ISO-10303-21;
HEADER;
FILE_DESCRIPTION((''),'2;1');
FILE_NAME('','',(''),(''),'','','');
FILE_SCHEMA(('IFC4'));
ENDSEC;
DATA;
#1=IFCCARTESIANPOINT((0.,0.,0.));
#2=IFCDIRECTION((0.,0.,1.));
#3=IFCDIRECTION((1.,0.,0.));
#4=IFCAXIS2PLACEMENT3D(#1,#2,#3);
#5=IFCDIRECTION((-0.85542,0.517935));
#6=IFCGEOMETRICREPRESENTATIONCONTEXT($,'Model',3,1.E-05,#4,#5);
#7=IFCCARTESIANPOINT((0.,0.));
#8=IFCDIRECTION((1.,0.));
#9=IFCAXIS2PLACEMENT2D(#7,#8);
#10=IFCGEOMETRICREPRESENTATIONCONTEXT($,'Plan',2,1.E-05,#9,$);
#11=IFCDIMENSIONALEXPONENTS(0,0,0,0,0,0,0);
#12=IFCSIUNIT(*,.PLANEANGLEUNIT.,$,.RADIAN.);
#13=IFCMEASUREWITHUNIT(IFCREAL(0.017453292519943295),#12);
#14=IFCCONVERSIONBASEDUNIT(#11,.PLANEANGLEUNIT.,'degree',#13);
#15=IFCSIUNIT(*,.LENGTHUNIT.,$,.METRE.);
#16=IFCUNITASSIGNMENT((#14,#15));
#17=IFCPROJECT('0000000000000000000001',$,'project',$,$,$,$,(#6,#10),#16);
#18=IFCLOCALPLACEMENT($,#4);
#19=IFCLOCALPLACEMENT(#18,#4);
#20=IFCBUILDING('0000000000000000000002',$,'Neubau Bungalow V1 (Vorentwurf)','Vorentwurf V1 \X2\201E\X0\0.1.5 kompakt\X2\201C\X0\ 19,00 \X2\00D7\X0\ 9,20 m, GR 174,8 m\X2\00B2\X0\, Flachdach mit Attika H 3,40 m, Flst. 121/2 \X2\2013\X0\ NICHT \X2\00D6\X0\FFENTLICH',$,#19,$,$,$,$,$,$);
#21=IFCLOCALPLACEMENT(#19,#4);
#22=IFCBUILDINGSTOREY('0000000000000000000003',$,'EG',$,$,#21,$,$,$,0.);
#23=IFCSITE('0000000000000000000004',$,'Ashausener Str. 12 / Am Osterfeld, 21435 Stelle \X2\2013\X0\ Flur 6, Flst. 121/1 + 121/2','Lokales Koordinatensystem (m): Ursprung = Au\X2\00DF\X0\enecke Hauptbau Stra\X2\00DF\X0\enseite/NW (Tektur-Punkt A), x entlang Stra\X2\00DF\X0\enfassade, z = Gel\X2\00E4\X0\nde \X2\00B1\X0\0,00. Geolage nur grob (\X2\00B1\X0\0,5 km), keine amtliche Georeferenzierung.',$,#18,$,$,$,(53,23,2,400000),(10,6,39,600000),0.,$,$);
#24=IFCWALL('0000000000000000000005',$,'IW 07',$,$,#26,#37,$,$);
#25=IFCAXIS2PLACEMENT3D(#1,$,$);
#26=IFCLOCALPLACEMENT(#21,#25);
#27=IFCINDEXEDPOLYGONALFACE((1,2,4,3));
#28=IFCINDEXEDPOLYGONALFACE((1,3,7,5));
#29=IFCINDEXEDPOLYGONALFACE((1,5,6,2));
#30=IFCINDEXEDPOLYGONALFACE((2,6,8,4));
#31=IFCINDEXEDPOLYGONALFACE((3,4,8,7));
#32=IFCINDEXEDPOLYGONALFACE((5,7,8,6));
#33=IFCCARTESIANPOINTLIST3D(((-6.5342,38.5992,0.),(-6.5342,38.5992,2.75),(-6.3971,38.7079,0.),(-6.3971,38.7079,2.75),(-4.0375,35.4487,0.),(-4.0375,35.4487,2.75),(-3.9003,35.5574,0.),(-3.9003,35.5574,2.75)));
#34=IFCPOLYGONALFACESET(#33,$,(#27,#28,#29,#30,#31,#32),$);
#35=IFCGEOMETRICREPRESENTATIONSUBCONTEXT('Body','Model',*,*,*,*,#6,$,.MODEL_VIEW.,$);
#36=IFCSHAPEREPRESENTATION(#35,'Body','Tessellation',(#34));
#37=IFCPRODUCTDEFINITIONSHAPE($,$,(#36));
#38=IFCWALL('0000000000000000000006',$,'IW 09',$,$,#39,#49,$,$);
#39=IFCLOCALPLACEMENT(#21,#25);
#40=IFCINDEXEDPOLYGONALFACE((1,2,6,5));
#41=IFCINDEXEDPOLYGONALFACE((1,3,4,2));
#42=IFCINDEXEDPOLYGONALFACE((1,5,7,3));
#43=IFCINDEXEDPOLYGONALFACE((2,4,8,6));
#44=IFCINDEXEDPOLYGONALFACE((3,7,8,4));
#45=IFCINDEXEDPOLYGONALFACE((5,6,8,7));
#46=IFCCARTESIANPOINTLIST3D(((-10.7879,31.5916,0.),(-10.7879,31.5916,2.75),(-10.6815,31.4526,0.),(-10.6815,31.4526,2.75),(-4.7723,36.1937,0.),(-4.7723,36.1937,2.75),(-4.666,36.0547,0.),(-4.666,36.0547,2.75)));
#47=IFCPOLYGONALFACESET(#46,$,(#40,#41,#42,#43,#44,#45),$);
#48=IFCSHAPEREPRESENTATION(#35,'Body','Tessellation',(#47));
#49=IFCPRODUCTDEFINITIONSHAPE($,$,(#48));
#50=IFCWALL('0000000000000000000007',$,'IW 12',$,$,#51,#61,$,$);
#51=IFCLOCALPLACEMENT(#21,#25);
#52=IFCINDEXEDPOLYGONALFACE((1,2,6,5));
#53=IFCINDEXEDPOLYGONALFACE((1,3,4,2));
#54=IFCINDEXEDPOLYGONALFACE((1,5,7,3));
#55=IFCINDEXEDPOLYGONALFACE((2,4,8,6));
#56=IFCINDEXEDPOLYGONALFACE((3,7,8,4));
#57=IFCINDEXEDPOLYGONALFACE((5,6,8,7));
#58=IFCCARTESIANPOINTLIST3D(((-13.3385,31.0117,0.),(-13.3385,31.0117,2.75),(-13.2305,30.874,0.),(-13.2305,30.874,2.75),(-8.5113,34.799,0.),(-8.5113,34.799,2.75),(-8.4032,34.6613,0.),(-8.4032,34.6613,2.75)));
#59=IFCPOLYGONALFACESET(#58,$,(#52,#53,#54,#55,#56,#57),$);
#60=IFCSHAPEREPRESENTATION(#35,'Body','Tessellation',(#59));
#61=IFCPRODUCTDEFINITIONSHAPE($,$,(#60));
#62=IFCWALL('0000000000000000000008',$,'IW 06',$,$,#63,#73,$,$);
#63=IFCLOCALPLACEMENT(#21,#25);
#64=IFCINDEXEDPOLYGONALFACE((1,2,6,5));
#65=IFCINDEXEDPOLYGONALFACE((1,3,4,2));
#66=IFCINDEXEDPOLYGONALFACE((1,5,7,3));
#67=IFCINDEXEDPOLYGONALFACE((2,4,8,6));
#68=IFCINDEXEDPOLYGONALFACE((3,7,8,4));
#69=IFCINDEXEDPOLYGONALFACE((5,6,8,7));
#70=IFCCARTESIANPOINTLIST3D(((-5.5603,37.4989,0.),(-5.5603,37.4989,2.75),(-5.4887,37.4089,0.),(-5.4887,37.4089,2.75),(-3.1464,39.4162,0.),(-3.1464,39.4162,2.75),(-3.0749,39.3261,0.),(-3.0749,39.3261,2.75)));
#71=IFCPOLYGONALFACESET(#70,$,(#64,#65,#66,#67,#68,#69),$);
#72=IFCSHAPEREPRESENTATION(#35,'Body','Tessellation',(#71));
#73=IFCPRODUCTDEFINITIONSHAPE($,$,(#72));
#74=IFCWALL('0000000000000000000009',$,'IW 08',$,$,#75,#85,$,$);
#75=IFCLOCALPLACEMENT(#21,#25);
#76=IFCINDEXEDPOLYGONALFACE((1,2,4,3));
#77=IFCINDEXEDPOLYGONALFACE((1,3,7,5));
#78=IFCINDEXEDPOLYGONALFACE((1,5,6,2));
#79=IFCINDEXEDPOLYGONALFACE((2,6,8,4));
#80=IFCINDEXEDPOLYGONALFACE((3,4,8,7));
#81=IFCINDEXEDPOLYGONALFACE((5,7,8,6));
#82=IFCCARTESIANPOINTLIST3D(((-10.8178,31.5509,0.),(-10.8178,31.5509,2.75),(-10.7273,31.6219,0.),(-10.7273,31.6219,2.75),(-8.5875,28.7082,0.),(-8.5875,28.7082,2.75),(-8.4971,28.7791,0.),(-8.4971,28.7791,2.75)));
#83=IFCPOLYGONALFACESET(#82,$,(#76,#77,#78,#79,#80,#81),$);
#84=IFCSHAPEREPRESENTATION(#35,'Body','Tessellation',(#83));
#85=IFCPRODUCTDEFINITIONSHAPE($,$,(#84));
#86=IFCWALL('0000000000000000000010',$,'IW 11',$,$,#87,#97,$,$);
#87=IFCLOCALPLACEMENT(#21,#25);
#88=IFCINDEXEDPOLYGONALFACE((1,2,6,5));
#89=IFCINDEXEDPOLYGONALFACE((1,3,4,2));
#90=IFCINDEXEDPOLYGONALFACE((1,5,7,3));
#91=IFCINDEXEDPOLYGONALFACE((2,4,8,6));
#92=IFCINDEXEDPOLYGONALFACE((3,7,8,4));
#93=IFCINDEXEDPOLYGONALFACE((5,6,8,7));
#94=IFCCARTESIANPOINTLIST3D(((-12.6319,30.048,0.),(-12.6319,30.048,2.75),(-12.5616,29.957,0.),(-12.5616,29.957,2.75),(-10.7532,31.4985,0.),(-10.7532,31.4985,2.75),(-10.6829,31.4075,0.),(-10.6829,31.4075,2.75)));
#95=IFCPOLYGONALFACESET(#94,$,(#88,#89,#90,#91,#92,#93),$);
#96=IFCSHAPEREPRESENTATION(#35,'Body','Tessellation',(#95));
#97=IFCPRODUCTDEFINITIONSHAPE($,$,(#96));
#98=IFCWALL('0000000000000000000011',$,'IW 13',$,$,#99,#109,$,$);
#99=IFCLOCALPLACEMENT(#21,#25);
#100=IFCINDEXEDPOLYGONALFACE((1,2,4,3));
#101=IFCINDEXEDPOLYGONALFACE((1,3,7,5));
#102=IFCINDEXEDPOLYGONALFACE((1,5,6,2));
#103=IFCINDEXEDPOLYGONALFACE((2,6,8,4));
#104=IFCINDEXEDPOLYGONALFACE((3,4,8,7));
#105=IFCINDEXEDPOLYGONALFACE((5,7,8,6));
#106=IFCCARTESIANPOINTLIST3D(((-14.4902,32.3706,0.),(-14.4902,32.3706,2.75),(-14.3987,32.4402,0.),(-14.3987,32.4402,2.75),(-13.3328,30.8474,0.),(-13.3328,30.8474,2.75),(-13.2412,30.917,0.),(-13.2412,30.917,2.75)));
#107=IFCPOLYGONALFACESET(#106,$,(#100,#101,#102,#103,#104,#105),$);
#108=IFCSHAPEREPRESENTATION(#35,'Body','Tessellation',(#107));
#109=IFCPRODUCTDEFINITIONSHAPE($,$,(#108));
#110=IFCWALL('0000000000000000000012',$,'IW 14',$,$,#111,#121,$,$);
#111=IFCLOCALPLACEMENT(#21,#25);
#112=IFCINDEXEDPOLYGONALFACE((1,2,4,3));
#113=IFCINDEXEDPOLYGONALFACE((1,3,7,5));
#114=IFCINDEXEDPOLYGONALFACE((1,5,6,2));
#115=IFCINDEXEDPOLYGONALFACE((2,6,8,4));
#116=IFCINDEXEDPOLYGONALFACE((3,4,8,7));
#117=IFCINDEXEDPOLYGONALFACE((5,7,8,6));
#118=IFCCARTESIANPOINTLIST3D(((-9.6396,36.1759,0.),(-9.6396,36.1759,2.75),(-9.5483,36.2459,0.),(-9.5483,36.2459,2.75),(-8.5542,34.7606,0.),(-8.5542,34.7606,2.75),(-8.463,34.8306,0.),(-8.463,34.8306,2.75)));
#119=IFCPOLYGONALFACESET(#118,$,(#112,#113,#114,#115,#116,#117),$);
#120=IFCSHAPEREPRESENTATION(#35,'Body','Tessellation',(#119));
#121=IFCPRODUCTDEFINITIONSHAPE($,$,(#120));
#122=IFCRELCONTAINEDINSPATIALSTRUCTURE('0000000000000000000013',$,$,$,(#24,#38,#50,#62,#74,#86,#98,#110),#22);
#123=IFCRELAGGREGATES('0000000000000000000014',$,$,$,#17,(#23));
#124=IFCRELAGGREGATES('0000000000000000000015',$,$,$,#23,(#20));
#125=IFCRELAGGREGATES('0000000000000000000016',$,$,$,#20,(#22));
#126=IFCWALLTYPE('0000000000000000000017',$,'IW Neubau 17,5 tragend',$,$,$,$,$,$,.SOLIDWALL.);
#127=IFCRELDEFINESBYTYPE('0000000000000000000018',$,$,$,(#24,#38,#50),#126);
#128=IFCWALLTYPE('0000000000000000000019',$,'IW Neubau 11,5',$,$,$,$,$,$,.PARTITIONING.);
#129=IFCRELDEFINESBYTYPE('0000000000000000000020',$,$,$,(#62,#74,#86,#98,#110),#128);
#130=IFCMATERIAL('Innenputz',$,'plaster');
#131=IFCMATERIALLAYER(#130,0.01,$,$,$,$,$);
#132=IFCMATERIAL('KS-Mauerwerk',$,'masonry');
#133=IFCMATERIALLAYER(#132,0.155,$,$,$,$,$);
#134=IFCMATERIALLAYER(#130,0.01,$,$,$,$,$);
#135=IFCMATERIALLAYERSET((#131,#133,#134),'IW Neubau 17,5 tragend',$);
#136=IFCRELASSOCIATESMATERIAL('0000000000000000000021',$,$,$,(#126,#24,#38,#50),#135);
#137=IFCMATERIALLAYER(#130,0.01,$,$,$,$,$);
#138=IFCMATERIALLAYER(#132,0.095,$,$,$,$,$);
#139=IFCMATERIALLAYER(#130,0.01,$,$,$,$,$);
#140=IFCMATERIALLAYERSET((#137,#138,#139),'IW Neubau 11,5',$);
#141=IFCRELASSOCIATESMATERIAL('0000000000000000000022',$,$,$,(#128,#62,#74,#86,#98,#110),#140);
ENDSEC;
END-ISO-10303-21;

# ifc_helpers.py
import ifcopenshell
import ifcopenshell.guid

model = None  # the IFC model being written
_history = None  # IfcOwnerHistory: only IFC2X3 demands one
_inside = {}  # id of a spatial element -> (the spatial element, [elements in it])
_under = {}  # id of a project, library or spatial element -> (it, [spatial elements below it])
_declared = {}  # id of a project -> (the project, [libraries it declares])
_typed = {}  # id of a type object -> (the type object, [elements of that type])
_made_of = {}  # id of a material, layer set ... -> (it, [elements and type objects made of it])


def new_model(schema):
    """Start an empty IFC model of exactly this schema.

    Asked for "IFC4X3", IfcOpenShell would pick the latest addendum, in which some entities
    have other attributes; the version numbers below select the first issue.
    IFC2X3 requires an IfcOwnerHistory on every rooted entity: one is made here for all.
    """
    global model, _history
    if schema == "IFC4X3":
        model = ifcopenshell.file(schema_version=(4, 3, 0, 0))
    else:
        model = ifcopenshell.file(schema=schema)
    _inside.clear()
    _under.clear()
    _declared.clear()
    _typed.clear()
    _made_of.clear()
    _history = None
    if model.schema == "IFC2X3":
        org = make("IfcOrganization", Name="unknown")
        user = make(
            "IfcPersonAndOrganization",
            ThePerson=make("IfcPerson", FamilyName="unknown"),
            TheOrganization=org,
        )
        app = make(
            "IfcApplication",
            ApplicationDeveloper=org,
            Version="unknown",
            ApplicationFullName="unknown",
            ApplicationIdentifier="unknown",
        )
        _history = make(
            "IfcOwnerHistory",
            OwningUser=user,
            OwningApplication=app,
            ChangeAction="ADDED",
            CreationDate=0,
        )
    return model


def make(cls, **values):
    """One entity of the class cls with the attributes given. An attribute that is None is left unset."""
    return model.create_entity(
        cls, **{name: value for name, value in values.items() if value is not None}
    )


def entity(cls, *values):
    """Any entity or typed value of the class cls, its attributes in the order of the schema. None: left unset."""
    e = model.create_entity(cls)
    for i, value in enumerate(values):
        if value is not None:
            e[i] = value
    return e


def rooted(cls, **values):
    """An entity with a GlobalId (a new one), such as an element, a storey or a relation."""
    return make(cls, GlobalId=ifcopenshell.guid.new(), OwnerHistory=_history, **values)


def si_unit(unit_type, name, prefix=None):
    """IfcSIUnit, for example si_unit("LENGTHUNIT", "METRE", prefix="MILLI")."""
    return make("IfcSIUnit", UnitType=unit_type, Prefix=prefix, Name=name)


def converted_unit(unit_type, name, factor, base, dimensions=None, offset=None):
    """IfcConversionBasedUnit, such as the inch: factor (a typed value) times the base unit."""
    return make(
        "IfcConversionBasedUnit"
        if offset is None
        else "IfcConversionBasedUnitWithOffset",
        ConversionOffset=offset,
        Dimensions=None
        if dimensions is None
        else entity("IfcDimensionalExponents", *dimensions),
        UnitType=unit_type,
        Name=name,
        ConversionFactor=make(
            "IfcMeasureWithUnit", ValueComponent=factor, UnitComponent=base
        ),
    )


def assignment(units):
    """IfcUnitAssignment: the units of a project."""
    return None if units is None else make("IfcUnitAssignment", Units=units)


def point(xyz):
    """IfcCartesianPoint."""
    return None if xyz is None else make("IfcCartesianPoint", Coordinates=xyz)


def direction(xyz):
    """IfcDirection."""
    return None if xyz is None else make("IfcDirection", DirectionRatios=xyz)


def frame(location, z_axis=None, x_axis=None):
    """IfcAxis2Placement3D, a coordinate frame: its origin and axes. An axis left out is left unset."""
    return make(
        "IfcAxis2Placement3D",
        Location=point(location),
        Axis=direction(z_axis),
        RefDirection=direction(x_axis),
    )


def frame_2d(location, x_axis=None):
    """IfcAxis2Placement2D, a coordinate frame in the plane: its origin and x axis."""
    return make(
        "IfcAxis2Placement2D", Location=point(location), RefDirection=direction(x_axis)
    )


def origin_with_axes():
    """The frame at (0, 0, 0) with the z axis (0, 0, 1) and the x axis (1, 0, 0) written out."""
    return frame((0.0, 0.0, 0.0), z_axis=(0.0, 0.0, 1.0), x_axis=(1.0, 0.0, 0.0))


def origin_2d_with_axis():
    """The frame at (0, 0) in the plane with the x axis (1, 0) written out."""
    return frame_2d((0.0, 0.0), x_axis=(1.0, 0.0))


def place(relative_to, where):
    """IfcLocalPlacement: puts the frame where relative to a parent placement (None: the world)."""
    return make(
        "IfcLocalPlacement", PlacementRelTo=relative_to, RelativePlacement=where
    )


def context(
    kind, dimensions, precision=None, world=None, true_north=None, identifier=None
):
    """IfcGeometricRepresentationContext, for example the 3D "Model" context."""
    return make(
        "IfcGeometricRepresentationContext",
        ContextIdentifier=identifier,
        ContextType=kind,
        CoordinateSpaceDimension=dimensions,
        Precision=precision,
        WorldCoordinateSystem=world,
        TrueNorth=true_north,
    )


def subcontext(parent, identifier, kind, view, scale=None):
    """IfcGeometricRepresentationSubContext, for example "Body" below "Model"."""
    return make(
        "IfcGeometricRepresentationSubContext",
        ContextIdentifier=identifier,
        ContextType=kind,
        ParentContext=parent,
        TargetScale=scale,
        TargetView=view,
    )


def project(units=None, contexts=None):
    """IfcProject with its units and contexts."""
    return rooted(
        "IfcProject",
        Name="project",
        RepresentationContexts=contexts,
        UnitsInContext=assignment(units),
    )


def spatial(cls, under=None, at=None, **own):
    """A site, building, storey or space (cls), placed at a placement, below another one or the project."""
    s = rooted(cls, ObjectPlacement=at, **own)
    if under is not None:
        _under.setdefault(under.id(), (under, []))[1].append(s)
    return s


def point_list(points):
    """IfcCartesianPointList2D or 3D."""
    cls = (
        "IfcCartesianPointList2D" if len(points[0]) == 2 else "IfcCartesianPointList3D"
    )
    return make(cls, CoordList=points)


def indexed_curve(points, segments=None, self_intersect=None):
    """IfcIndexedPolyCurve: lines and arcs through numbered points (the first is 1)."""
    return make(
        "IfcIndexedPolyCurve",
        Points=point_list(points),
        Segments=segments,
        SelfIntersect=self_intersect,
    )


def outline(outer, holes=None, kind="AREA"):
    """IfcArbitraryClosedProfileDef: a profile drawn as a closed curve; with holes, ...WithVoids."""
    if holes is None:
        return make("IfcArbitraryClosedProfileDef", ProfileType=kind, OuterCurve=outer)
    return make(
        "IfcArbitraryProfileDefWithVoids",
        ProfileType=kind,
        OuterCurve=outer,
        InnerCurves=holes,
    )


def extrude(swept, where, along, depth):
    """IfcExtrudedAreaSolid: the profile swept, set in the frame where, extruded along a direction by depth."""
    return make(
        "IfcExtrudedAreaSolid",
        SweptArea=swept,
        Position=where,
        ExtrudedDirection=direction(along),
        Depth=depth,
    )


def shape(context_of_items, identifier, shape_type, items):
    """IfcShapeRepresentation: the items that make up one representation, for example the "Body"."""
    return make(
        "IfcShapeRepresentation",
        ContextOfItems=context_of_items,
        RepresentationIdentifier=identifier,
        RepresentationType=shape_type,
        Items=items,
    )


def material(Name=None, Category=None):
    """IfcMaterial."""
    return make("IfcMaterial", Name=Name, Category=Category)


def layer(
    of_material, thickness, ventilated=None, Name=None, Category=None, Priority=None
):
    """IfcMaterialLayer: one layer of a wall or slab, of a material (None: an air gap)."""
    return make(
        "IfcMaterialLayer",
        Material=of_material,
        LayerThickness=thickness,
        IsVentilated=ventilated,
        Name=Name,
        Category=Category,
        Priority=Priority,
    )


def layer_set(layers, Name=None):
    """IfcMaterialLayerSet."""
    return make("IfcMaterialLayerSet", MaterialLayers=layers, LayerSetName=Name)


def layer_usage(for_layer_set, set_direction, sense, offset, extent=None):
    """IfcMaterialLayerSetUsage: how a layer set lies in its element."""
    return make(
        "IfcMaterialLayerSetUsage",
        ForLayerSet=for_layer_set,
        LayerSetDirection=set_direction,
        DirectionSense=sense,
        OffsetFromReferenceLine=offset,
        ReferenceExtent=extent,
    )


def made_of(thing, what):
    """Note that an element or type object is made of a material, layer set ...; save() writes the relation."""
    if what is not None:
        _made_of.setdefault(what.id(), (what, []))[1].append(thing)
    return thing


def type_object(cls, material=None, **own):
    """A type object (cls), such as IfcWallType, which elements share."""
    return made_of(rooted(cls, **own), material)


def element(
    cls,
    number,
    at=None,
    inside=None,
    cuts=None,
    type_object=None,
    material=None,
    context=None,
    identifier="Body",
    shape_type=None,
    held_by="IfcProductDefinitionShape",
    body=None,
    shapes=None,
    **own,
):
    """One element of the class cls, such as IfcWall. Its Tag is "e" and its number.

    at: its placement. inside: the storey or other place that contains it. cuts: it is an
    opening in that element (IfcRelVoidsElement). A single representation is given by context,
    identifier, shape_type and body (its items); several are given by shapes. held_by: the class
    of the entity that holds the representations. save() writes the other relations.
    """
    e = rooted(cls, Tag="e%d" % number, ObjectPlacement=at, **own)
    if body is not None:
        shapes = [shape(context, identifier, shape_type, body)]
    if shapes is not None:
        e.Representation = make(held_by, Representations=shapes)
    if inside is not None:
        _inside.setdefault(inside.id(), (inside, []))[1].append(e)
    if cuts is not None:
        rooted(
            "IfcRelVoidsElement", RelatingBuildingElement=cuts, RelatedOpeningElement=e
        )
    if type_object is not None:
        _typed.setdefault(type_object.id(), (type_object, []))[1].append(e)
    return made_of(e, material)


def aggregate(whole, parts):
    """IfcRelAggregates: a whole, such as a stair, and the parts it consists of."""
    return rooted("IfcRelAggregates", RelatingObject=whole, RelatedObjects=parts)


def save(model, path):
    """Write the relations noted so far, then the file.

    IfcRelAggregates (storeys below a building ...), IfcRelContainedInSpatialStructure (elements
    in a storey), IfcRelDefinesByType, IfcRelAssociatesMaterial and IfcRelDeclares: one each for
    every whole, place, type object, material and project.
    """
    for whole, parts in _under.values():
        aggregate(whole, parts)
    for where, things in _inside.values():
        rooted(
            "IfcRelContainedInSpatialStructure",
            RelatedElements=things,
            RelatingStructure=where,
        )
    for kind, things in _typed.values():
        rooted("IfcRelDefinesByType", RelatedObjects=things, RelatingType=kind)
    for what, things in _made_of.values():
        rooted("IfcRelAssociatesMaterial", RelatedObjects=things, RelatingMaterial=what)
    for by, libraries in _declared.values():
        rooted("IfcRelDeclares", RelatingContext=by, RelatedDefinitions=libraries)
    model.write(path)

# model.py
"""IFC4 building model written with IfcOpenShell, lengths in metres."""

from ifc_helpers import new_model, entity, si_unit, converted_unit, direction, frame, origin_with_axes, origin_2d_with_axis, place, context, subcontext, project, spatial, indexed_curve, outline, extrude, material, layer, layer_set, layer_usage, type_object, element, save


model = new_model("IFC4")

# Units and contexts
model_context = context("Model", 3, precision=1e-05, world=origin_with_axes(), true_north=direction((-0.85542, 0.517935)))
plan_context = context("Plan", 2, precision=1e-05, world=origin_2d_with_axis())
body_context = subcontext(model_context, "Body", "Model", "MODEL_VIEW")
ifc_project = project(units=[converted_unit("PLANEANGLEUNIT", "degree", entity("IfcReal", 0.017453292519943295), si_unit("PLANEANGLEUNIT", "RADIAN"), dimensions=[0, 0, 0, 0, 0, 0, 0]), si_unit("LENGTHUNIT", "METRE")], contexts=[model_context, plan_context])

# Site, building, storey
site_placement = place(None, origin_with_axes())
site = spatial("IfcSite", under=ifc_project, at=site_placement, Name="Ashausener Str. 12 / Am Osterfeld, 21435 Stelle – Flur 6, Flst. 121/1 + 121/2", Description="Lokales Koordinatensystem (m): Ursprung = Außenecke Hauptbau Straßenseite/NW (Tektur-Punkt A), x entlang Straßenfassade, z = Gelände ±0,00. Geolage nur grob (±0,5 km), keine amtliche Georeferenzierung.", RefLatitude=(53, 23, 2, 400000), RefLongitude=(10, 6, 39, 600000), RefElevation=0.0)
building_placement = place(site_placement, origin_with_axes())
building = spatial("IfcBuilding", under=site, at=building_placement, Name="Neubau Bungalow V1 (Vorentwurf)", Description="Vorentwurf V1 „0.1.5 kompakt“ 19,00 × 9,20 m, GR 174,8 m², Flachdach mit Attika H 3,40 m, Flst. 121/2 – NICHT ÖFFENTLICH")
storey_placement = place(building_placement, origin_with_axes())
storey = spatial("IfcBuildingStorey", under=building, at=storey_placement, Name="EG", Elevation=0.0)

# Shared definitions
ifc_material_1 = material(Name="KS-Mauerwerk", Category="masonry")
ifc_material_2 = material(Name="Innenputz", Category="plaster")

# Walls
ifc_layer_1 = layer(ifc_material_2, 0.01)
ifc_layer_2 = layer(ifc_material_1, 0.155)
ifc_layer_3 = layer(ifc_material_2, 0.01)
ifc_layer_set_1 = layer_set([ifc_layer_1, ifc_layer_2, ifc_layer_3], Name="IW Neubau 17,5 tragend")
ifc_layer_usage_1 = layer_usage(ifc_layer_set_1, "AXIS2", "POSITIVE", -0.0875)
wall_type_1 = type_object("IfcWallType", Name="IW Neubau 17,5 tragend", PredefinedType="SOLIDWALL", material=ifc_layer_set_1)
wall_1_placement = place(storey_placement, frame((-6.4657, 38.6535, 0.0), z_axis=(0.0, 0.0, 1.0), x_axis=(0.621106, -0.783727, 0.0)))
element("IfcWall", 1, at=wall_1_placement, inside=storey, type_object=wall_type_1, material=ifc_layer_usage_1, Name="IW 07", context=body_context, shape_type="SweptSolid", body=[
    extrude(outline(indexed_curve([(0.0, 0.0), (0.0, 0.175), (4.0199, 0.175), (4.0199, 0.0), (0.0, 0.0)], self_intersect=False)), frame((0.0, -0.0875, 0.0), z_axis=(0.0, 0.0, 1.0), x_axis=(1.0, 0.0, 0.0)), (0.0, 0.0, 1.0), 2.75),
])
ifc_layer_usage_2 = layer_usage(ifc_layer_set_1, "AXIS2", "POSITIVE", -0.0875)
wall_2_placement = place(storey_placement, frame((-10.7347, 31.5221, 0.0), z_axis=(0.0, 0.0, 1.0), x_axis=(0.794233, 0.607613, 0.0)))
element("IfcWall", 2, at=wall_2_placement, inside=storey, type_object=wall_type_1, material=ifc_layer_usage_2, Name="IW 09", context=body_context, shape_type="SweptSolid", body=[
    extrude(outline(indexed_curve([(0.0, 0.0), (0.0, 0.175), (7.574, 0.175), (7.574, 0.0), (0.0, 0.0)], self_intersect=False)), frame((0.0, -0.0875, 0.0), z_axis=(0.0, 0.0, 1.0), x_axis=(1.0, 0.0, 0.0)), (0.0, 0.0, 1.0), 2.75),
])
ifc_layer_usage_3 = layer_usage(ifc_layer_set_1, "AXIS2", "POSITIVE", -0.0875)
wall_3_placement = place(storey_placement, frame((-13.2845, 30.9429, 0.0), z_axis=(0.0, 0.0, 1.0), x_axis=(0.786761, 0.617258, 0.0)))
element("IfcWall", 3, at=wall_3_placement, inside=storey, type_object=wall_type_1, material=ifc_layer_usage_3, Name="IW 12", context=body_context, shape_type="SweptSolid", body=[
    extrude(outline(indexed_curve([(0.0, 0.0), (0.0, 0.175), (6.1356, 0.175), (6.1356, 0.0), (0.0, 0.0)], self_intersect=False)), frame((0.0, -0.0875, 0.0), z_axis=(0.0, 0.0, 1.0), x_axis=(1.0, 0.0, 0.0)), (0.0, 0.0, 1.0), 2.75),
])
ifc_layer_4 = layer(ifc_material_2, 0.01)
ifc_layer_5 = layer(ifc_material_1, 0.095)
ifc_layer_6 = layer(ifc_material_2, 0.01)
ifc_layer_set_2 = layer_set([ifc_layer_4, ifc_layer_5, ifc_layer_6], Name="IW Neubau 11,5")
ifc_layer_usage_4 = layer_usage(ifc_layer_set_2, "AXIS2", "POSITIVE", -0.0575)
wall_type_2 = type_object("IfcWallType", Name="IW Neubau 11,5", PredefinedType="PARTITIONING", material=ifc_layer_set_2)
wall_4_placement = place(storey_placement, frame((-5.5245, 37.4539, 0.0), z_axis=(0.0, 0.0, 1.0), x_axis=(0.783046, 0.621964, 0.0)))
element("IfcWall", 4, at=wall_4_placement, inside=storey, type_object=wall_type_2, material=ifc_layer_usage_4, Name="IW 06", context=body_context, shape_type="SweptSolid", body=[
    extrude(outline(indexed_curve([(0.0, 0.0), (0.0, 0.115), (3.0826, 0.115), (3.0826, 0.0), (0.0, 0.0)], self_intersect=False)), frame((0.0, -0.0575, 0.0), z_axis=(0.0, 0.0, 1.0), x_axis=(1.0, 0.0, 0.0)), (0.0, 0.0, 1.0), 2.75),
])
ifc_layer_usage_5 = layer_usage(ifc_layer_set_2, "AXIS2", "POSITIVE", -0.0575)
wall_5_placement = place(storey_placement, frame((-10.7726, 31.5864, 0.0), z_axis=(0.0, 0.0, 1.0), x_axis=(0.617258, -0.786761, 0.0)))
element("IfcWall", 5, at=wall_5_placement, inside=storey, type_object=wall_type_2, material=ifc_layer_usage_5, Name="IW 08", context=body_context, shape_type="SweptSolid", body=[
    extrude(outline(indexed_curve([(0.0, 0.0), (0.0, 0.115), (3.6132, 0.115), (3.6132, 0.0), (0.0, 0.0)], self_intersect=False)), frame((0.0, -0.0575, 0.0), z_axis=(0.0, 0.0, 1.0), x_axis=(1.0, 0.0, 0.0)), (0.0, 0.0, 1.0), 2.75),
])
ifc_layer_usage_6 = layer_usage(ifc_layer_set_2, "AXIS2", "POSITIVE", -0.0575)
wall_6_placement = place(storey_placement, frame((-12.5968, 30.0025, 0.0), z_axis=(0.0, 0.0, 1.0), x_axis=(0.791543, 0.611113, 0.0)))
element("IfcWall", 6, at=wall_6_placement, inside=storey, type_object=wall_type_2, material=ifc_layer_usage_6, Name="IW 11", context=body_context, shape_type="SweptSolid", body=[
    extrude(outline(indexed_curve([(0.0, 0.0), (0.0, 0.115), (2.3736, 0.115), (2.3736, 0.0), (0.0, 0.0)], self_intersect=False)), frame((0.0, -0.0575, 0.0), z_axis=(0.0, 0.0, 1.0), x_axis=(1.0, 0.0, 0.0)), (0.0, 0.0, 1.0), 2.75),
])
ifc_layer_usage_7 = layer_usage(ifc_layer_set_2, "AXIS2", "POSITIVE", -0.0575)
wall_7_placement = place(storey_placement, frame((-14.4445, 32.4054, 0.0), z_axis=(0.0, 0.0, 1.0), x_axis=(0.605034, -0.7962, 0.0)))
element("IfcWall", 7, at=wall_7_placement, inside=storey, type_object=wall_type_2, material=ifc_layer_usage_7, Name="IW 13", context=body_context, shape_type="SweptSolid", body=[
    extrude(outline(indexed_curve([(0.0, 0.0), (0.0, 0.115), (1.9131, 0.115), (1.9131, 0.0), (0.0, 0.0)], self_intersect=False)), frame((0.0, -0.0575, 0.0), z_axis=(0.0, 0.0, 1.0), x_axis=(1.0, 0.0, 0.0)), (0.0, 0.0, 1.0), 2.75),
])
ifc_layer_usage_8 = layer_usage(ifc_layer_set_2, "AXIS2", "POSITIVE", -0.0575)
wall_8_placement = place(storey_placement, frame((-9.594, 36.2109, 0.0), z_axis=(0.0, 0.0, 1.0), x_axis=(0.608532, -0.793529, 0.0)))
element("IfcWall", 8, at=wall_8_placement, inside=storey, type_object=wall_type_2, material=ifc_layer_usage_8, Name="IW 14", context=body_context, shape_type="SweptSolid", body=[
    extrude(outline(indexed_curve([(0.0, 0.0), (0.0, 0.115), (1.7836, 0.115), (1.7836, 0.0), (0.0, 0.0)], self_intersect=False)), frame((0.0, -0.0575, 0.0), z_axis=(0.0, 0.0, 1.0), x_axis=(1.0, 0.0, 0.0)), (0.0, 0.0, 1.0), 2.75),
])

save(model, "model.ifc")
